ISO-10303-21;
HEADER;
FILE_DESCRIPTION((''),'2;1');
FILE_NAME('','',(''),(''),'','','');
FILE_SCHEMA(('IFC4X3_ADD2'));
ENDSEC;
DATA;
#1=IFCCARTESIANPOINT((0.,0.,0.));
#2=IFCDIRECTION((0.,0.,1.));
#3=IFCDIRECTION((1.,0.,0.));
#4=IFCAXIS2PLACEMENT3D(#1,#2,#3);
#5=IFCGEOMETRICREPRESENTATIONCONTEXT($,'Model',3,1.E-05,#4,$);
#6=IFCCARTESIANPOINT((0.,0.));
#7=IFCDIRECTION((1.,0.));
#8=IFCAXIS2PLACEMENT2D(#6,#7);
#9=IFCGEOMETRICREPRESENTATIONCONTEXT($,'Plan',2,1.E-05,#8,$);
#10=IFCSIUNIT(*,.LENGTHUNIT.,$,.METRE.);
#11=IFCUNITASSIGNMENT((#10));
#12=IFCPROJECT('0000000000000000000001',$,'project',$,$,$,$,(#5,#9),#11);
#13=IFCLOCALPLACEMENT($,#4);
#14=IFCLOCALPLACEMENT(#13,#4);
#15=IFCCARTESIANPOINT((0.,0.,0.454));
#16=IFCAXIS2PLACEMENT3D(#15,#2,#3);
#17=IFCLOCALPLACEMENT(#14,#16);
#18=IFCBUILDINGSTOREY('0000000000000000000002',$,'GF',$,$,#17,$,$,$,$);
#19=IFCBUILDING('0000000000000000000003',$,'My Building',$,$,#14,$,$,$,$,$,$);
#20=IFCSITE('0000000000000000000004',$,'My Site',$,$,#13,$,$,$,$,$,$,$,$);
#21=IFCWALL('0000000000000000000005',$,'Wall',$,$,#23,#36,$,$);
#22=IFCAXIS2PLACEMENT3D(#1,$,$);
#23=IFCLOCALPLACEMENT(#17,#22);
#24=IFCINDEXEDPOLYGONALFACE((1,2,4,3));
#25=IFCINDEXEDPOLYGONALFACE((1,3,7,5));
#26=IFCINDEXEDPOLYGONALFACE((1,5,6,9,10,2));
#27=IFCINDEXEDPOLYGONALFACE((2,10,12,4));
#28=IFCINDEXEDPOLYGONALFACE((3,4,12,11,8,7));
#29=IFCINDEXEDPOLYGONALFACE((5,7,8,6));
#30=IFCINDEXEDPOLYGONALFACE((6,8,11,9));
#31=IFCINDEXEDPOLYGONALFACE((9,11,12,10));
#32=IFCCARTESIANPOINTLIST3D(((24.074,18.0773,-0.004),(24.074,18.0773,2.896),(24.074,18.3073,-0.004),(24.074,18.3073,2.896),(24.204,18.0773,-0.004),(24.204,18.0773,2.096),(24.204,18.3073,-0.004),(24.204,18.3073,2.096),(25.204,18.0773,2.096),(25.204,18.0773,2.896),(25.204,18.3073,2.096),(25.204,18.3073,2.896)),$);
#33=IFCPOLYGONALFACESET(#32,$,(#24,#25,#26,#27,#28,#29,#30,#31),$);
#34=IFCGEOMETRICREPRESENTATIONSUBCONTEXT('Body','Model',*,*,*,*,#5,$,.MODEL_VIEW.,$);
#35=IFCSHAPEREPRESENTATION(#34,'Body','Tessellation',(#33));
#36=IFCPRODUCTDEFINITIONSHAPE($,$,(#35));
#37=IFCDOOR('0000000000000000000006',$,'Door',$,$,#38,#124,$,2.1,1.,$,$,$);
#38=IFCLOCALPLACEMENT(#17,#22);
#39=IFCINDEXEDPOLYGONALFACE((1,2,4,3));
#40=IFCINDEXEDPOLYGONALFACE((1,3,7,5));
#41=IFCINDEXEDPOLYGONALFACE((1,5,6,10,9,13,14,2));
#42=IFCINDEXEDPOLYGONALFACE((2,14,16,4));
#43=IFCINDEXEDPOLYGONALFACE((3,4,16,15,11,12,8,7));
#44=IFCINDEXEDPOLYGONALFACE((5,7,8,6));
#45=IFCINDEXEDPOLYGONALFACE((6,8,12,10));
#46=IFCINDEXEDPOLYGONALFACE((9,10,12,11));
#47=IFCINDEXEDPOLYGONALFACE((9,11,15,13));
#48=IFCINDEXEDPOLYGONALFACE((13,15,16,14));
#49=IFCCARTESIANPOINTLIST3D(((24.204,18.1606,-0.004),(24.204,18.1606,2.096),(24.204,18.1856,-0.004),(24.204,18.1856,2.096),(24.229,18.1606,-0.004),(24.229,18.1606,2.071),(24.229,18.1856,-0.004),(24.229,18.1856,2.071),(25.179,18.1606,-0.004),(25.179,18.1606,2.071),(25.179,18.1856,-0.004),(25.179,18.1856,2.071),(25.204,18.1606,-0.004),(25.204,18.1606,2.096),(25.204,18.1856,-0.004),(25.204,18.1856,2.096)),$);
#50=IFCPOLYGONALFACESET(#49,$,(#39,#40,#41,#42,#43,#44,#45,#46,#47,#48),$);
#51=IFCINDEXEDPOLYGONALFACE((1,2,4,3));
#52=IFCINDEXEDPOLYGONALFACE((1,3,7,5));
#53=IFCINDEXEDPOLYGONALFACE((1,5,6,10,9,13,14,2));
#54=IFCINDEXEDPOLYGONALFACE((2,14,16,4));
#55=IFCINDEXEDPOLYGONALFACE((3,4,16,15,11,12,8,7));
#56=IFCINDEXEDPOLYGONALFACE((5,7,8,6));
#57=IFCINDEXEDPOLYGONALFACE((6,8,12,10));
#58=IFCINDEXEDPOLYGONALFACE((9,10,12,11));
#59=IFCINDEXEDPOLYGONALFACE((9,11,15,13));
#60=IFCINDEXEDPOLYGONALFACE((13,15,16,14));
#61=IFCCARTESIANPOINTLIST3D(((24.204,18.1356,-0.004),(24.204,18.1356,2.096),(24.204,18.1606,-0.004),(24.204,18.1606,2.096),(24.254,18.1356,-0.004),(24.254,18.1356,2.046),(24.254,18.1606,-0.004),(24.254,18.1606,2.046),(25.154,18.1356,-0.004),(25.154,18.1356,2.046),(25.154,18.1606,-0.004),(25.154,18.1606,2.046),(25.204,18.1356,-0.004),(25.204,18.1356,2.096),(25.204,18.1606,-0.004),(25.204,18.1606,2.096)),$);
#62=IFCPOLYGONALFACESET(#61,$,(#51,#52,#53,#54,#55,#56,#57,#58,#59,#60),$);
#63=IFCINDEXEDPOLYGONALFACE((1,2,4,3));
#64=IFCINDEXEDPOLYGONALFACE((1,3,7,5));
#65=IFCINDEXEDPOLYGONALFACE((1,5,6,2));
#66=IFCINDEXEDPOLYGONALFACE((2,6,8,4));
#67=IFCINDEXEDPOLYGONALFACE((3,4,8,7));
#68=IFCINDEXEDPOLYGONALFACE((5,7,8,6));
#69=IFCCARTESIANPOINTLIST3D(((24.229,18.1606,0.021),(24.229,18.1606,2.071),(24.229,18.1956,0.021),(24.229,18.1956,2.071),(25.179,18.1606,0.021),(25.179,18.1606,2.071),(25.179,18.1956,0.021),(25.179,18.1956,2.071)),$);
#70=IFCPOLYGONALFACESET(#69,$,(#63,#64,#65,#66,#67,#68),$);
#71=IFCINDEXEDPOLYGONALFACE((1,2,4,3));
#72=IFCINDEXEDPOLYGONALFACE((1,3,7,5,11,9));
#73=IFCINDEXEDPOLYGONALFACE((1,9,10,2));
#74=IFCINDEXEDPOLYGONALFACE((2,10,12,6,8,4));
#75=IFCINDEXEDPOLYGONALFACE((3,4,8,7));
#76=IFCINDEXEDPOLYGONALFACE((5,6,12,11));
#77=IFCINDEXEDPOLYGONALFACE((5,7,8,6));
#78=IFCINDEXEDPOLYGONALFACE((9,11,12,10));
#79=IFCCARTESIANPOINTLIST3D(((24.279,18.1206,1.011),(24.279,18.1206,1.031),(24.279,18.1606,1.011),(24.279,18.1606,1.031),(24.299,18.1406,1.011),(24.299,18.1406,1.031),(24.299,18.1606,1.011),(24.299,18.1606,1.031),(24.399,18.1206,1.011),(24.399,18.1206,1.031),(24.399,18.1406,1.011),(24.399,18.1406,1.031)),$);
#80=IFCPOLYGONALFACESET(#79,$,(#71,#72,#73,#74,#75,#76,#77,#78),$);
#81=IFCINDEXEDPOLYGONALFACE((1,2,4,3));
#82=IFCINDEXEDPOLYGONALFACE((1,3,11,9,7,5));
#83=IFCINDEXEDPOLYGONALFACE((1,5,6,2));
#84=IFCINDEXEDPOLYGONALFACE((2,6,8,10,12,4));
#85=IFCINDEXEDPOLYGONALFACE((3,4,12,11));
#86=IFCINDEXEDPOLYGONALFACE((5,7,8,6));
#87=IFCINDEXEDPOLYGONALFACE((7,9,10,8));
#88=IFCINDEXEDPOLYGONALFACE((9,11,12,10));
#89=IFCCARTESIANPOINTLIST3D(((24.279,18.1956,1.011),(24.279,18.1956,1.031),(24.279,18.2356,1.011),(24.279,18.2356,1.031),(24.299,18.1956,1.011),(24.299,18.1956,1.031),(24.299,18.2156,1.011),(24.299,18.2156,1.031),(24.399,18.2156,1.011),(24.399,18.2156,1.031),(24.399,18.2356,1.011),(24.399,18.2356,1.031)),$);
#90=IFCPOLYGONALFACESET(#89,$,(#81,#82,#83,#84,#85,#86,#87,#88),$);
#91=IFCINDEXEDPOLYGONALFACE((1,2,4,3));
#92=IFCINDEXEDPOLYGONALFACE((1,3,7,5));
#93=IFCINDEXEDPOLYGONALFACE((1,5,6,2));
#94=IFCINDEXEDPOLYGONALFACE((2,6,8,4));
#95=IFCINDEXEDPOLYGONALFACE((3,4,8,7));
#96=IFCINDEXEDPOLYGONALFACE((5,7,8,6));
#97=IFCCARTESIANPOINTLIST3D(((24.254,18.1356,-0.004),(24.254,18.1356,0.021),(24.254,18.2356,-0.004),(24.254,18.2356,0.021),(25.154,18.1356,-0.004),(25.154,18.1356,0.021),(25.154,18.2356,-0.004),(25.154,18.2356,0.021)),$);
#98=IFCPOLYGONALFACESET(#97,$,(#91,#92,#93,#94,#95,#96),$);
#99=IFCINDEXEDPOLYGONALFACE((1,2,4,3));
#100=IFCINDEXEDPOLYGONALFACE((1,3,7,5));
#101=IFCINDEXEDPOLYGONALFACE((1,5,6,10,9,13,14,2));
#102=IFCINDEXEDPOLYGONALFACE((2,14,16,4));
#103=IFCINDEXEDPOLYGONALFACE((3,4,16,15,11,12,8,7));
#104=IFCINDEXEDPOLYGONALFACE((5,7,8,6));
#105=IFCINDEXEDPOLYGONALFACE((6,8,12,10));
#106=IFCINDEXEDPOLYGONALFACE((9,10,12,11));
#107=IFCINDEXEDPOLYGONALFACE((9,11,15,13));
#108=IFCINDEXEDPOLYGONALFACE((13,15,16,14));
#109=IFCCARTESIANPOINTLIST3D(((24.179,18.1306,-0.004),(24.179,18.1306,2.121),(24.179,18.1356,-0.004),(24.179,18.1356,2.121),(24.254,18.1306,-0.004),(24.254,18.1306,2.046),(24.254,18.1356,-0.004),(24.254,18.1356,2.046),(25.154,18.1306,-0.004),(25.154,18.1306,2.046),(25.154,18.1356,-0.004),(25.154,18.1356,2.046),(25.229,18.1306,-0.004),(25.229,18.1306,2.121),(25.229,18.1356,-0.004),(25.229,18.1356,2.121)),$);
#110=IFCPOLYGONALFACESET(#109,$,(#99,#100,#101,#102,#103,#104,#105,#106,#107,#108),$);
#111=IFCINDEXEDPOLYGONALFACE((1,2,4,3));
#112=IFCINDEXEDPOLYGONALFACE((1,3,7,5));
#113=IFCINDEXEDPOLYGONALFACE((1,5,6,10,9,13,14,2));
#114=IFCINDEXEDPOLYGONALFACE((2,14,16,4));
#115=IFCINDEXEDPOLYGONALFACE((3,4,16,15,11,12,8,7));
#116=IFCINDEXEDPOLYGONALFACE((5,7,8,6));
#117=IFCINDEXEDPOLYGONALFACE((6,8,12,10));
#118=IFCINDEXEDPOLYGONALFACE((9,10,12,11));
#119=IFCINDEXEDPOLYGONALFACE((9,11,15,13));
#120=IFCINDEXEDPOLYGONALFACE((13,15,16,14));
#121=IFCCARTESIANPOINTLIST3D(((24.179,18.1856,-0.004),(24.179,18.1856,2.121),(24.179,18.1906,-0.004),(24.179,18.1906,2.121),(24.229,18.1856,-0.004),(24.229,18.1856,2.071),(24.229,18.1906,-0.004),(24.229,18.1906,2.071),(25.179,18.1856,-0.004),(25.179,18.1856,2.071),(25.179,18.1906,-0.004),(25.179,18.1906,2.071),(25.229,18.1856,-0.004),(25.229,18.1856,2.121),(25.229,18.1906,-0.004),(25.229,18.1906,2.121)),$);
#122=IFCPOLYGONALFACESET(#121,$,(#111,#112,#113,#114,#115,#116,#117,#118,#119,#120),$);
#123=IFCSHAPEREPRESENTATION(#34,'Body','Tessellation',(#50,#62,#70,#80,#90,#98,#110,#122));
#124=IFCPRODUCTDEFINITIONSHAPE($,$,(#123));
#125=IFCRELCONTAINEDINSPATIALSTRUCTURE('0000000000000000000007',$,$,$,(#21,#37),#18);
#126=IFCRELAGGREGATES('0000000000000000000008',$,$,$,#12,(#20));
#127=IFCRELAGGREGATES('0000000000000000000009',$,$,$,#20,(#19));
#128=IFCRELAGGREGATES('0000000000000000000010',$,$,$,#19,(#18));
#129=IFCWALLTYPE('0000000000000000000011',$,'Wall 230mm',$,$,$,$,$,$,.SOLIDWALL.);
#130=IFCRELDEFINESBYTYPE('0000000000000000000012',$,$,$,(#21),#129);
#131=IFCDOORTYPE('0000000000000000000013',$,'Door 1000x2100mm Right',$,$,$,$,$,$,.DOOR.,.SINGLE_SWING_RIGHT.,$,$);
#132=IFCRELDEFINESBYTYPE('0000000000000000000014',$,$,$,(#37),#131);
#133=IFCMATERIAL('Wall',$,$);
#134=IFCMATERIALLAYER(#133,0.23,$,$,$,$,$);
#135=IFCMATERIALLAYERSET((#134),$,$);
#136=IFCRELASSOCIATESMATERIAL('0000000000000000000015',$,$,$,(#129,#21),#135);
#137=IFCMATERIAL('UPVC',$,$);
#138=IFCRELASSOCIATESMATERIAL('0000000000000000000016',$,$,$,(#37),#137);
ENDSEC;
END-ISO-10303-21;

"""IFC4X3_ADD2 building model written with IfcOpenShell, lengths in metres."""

from ifc_helpers import new_model, entity, si_unit, frame, origin_with_axes, origin_2d_with_axis, place, context, subcontext, project, spatial, line, indexed_curve, outline, extrude, shape, source, transform, mapped, material, layer, layer_set, layer_usage, type_object, type_shapes, element, fill, save


model = new_model("IFC4X3_ADD2")

# Units and contexts
model_context = context("Model", 3, precision=1e-05, world=origin_with_axes())
plan_context = context("Plan", 2, precision=1e-05, world=origin_2d_with_axis())
body_context_1 = subcontext(model_context, "Body", "Model", "MODEL_VIEW")
body_context_2 = subcontext(plan_context, "Body", "Plan", "PLAN_VIEW")
ifc_project = project(units=[si_unit("LENGTHUNIT", "METRE")], contexts=[model_context, plan_context])

# Site, building, storey
site_placement = place(None, origin_with_axes())
site = spatial("IfcSite", under=ifc_project, at=site_placement, Name="My Site")
building_placement = place(site_placement, origin_with_axes())
building = spatial("IfcBuilding", under=site, at=building_placement, Name="My Building")
storey_placement = place(building_placement, frame((0.0, 0.0, 0.454), z_axis=(0.0, 0.0, 1.0), x_axis=(1.0, 0.0, 0.0)))
storey = spatial("IfcBuildingStorey", under=building, at=storey_placement, Name="GF")

# Shared definitions
ifc_material_1 = material(Name="Wall")

# Shared definitions
ifc_material_2 = material(Name="UPVC")

# Shared definitions
ifc_layer_1 = layer(ifc_material_1, 0.23)
ifc_layer_set_1 = layer_set([ifc_layer_1])
wall_type_1 = type_object("IfcWallType", Name="Wall 230mm", PredefinedType="SOLIDWALL", material=ifc_layer_set_1)

# Shared definitions
shared_shape_1 = source(origin_with_axes(), body_context_1, "Body", "SweptSolid", [
    extrude(outline(indexed_curve([(0.0, 0.0), (1.0, 0.0), (1.0, 2.1), (0.0, 2.1)], segments=[line(1, 2, 3, 4, 1)])), frame((0.0, -0.6, 0.0), z_axis=(0.0, -1.0, 0.0), x_axis=(1.0, 0.0, 0.0)), (0.0, 0.0, -1.0), 1.2),
])
door_type_1 = type_object("IfcDoorType", Name="Door 1000x2100mm Right", OperationType="SINGLE_SWING_RIGHT", PredefinedType="DOOR")
shared_shape_2 = source(origin_with_axes(), body_context_1, "Body", "SweptSolid", [
    extrude(outline(indexed_curve([(0.0, 0.0), (0.0, 2.1), (1.0, 2.1), (1.0, 0.0), (0.975, 0.0), (0.975, 2.075), (0.025, 2.075), (0.025, 0.0)], segments=[line(1, 2, 3, 4, 5, 6, 7, 8, 1)])), frame((0.0, 0.025, 0.0), z_axis=(0.0, -1.0, 0.0), x_axis=(1.0, 0.0, 0.0)), (0.0, 0.0, -1.0), 0.025),
    extrude(outline(indexed_curve([(0.0, 0.0), (0.0, 2.1), (1.0, 2.1), (1.0, 0.0), (0.95, 0.0), (0.95, 2.05), (0.05, 2.05), (0.05, 0.0)], segments=[line(1, 2, 3, 4, 5, 6, 7, 8, 1)])), frame((0.0, 0.0, 0.0), z_axis=(0.0, -1.0, 0.0), x_axis=(1.0, 0.0, 0.0)), (0.0, 0.0, -1.0), 0.025),
    extrude(outline(indexed_curve([(0.0, 0.0), (0.95, 0.0), (0.95, 0.035), (0.0, 0.035)], segments=[line(1, 2, 3, 4, 1)])), frame((0.025, 0.025, 0.025), z_axis=(0.0, 0.0, 1.0), x_axis=(1.0, 0.0, 0.0)), (0.0, 0.0, 1.0), 2.05),
    extrude(outline(indexed_curve([(0.0, 0.0), (0.0, -0.04), (0.12, -0.04), (0.12, -0.02), (0.02, -0.02), (0.02, 0.0)], segments=[line(1, 2, 3, 4, 5, 6, 1)])), frame((0.075, 0.025, 1.015), z_axis=(0.0, 0.0, 1.0), x_axis=(1.0, 0.0, 0.0)), (0.0, 0.0, 1.0), 0.02),
    extrude(outline(indexed_curve([(0.0, 0.0), (0.0, 0.04), (0.12, 0.04), (0.12, 0.02), (0.02, 0.02), (0.02, 0.0)], segments=[line(1, 2, 3, 4, 5, 6, 1)])), frame((0.075, 0.06, 1.015), z_axis=(0.0, 0.0, 1.0), x_axis=(1.0, 0.0, 0.0)), (0.0, 0.0, 1.0), 0.02),
    extrude(outline(indexed_curve([(0.0, 0.0), (0.9, 0.0), (0.9, 0.1), (0.0, 0.1)], segments=[line(1, 2, 3, 4, 1)])), frame((0.05, 0.0, 0.0), z_axis=(0.0, 0.0, 1.0), x_axis=(1.0, 0.0, 0.0)), (0.0, 0.0, 1.0), 0.025),
    extrude(outline(indexed_curve([(0.0, 0.0), (0.0, 2.125), (1.05, 2.125), (1.05, 0.0), (0.975, 0.0), (0.975, 2.05), (0.075, 2.05), (0.075, 0.0)], segments=[line(1, 2, 3, 4, 5, 6, 7, 8, 1)])), frame((-0.025, -0.005, 0.0), z_axis=(0.0, -1.0, 0.0), x_axis=(1.0, 0.0, 0.0)), (0.0, 0.0, -1.0), 0.005),
    extrude(outline(indexed_curve([(0.0, 0.0), (0.0, 2.125), (1.05, 2.125), (1.05, 0.0), (1.0, 0.0), (1.0, 2.075), (0.05, 2.075), (0.05, 0.0)], segments=[line(1, 2, 3, 4, 5, 6, 7, 8, 1)])), frame((-0.025, 0.05, 0.0), z_axis=(0.0, -1.0, 0.0), x_axis=(1.0, 0.0, 0.0)), (0.0, 0.0, -1.0), 0.005),
])
shared_shape_3 = source(origin_with_axes(), body_context_2, "Body", "Curve2D", [
    entity("IfcIndexedPolyCurve", entity("IfcCartesianPointList2D", [[0.0, 0.0], [0.0, 0.05], [0.025, 0.05], [0.025, 0.025], [0.05, 0.025], [0.05, 0.0]]), [entity("IfcLineIndex", [1, 2, 3, 4, 5, 6, 1])]),
    entity("IfcIndexedPolyCurve", entity("IfcCartesianPointList2D", [[1.0, 0.0], [1.0, 0.05], [0.975, 0.05], [0.975, 0.025], [0.95, 0.025], [0.95, 0.0]]), [entity("IfcLineIndex", [1, 2, 3, 4, 5, 6, 1])]),
    entity("IfcTrimmedCurve", entity("IfcEllipse", entity("IfcAxis2Placement2D", entity("IfcCartesianPoint", [0.94, 0.05]), entity("IfcDirection", [1.0, 0.0])), 0.915, 0.95), [entity("IfcCartesianPoint", [0.94, 1.0])], [entity("IfcCartesianPoint", [0.025, 0.05])], True, "CARTESIAN"),
    entity("IfcIndexedPolyCurve", entity("IfcCartesianPointList2D", [[0.975, 0.05], [0.94, 0.05], [0.94, 1.0], [0.975, 1.0]]), [entity("IfcLineIndex", [1, 2, 3, 4, 1])]),
])
type_shapes(door_type_1, [shared_shape_2, shared_shape_3])

# Wall, opening, door
ifc_layer_usage_1 = layer_usage(ifc_layer_set_1, "AXIS2", "POSITIVE", 0.0)
wall_1_placement = place(storey_placement, frame((25.204, 18.3073, -0.004), z_axis=(0.0, 0.0, 1.0), x_axis=(-1.0, 0.0, 0.0)))
wall_1 = element("IfcWall", 1, at=wall_1_placement, inside=storey, type_object=wall_type_1, material=ifc_layer_usage_1, Name="Wall", context=body_context_1, shape_type="SweptSolid", body=[
    extrude(outline(indexed_curve([(0.0, 0.0), (0.0, 0.23), (1.13, 0.23), (1.13, 0.0), (0.0, 0.0)], self_intersect=False)), origin_with_axes(), (0.0, 0.0, 1.0), 2.9),
])
opening_1_placement = place(wall_1_placement, frame((0.0, 0.0, 0.0), z_axis=(0.0, 0.0, 1.0), x_axis=(1.0, 0.0, 0.0)))
opening_1 = element("IfcOpeningElement", 2, at=opening_1_placement, cuts=wall_1, PredefinedType="OPENING", context=body_context_1, shape_type="MappedRepresentation", body=[
    mapped(shared_shape_1, transform((0.0, 0.0, 0.0), x_axis=(1.0, 0.0, 0.0), y_axis=(0.0, 1.0, 0.0), z_axis=(0.0, 0.0, 1.0), scale=1.0)),
])
door_1_placement = place(opening_1_placement, frame((1.0, 0.1717, 0.0), z_axis=(0.0, 0.0, 1.0), x_axis=(-1.0, 0.0, 0.0)))
door_1 = element("IfcDoor", 3, at=door_1_placement, inside=storey, type_object=door_type_1, material=ifc_material_2, Name="Door", OverallHeight=2.1, OverallWidth=1.0, shapes=[
    shape(body_context_1, "Body", "MappedRepresentation", [mapped(shared_shape_2, transform((0.0, 0.0, 0.0), x_axis=(1.0, 0.0, 0.0), y_axis=(0.0, 1.0, 0.0), z_axis=(0.0, 0.0, 1.0), scale=1.0))]),
    shape(body_context_2, "Body", "MappedRepresentation", [mapped(shared_shape_3, transform((0.0, 0.0, 0.0), x_axis=(1.0, 0.0, 0.0), y_axis=(0.0, 1.0, 0.0), z_axis=(0.0, 0.0, 1.0), scale=1.0))]),
])
fill(opening_1, door_1)

save(model, "model.ifc")
